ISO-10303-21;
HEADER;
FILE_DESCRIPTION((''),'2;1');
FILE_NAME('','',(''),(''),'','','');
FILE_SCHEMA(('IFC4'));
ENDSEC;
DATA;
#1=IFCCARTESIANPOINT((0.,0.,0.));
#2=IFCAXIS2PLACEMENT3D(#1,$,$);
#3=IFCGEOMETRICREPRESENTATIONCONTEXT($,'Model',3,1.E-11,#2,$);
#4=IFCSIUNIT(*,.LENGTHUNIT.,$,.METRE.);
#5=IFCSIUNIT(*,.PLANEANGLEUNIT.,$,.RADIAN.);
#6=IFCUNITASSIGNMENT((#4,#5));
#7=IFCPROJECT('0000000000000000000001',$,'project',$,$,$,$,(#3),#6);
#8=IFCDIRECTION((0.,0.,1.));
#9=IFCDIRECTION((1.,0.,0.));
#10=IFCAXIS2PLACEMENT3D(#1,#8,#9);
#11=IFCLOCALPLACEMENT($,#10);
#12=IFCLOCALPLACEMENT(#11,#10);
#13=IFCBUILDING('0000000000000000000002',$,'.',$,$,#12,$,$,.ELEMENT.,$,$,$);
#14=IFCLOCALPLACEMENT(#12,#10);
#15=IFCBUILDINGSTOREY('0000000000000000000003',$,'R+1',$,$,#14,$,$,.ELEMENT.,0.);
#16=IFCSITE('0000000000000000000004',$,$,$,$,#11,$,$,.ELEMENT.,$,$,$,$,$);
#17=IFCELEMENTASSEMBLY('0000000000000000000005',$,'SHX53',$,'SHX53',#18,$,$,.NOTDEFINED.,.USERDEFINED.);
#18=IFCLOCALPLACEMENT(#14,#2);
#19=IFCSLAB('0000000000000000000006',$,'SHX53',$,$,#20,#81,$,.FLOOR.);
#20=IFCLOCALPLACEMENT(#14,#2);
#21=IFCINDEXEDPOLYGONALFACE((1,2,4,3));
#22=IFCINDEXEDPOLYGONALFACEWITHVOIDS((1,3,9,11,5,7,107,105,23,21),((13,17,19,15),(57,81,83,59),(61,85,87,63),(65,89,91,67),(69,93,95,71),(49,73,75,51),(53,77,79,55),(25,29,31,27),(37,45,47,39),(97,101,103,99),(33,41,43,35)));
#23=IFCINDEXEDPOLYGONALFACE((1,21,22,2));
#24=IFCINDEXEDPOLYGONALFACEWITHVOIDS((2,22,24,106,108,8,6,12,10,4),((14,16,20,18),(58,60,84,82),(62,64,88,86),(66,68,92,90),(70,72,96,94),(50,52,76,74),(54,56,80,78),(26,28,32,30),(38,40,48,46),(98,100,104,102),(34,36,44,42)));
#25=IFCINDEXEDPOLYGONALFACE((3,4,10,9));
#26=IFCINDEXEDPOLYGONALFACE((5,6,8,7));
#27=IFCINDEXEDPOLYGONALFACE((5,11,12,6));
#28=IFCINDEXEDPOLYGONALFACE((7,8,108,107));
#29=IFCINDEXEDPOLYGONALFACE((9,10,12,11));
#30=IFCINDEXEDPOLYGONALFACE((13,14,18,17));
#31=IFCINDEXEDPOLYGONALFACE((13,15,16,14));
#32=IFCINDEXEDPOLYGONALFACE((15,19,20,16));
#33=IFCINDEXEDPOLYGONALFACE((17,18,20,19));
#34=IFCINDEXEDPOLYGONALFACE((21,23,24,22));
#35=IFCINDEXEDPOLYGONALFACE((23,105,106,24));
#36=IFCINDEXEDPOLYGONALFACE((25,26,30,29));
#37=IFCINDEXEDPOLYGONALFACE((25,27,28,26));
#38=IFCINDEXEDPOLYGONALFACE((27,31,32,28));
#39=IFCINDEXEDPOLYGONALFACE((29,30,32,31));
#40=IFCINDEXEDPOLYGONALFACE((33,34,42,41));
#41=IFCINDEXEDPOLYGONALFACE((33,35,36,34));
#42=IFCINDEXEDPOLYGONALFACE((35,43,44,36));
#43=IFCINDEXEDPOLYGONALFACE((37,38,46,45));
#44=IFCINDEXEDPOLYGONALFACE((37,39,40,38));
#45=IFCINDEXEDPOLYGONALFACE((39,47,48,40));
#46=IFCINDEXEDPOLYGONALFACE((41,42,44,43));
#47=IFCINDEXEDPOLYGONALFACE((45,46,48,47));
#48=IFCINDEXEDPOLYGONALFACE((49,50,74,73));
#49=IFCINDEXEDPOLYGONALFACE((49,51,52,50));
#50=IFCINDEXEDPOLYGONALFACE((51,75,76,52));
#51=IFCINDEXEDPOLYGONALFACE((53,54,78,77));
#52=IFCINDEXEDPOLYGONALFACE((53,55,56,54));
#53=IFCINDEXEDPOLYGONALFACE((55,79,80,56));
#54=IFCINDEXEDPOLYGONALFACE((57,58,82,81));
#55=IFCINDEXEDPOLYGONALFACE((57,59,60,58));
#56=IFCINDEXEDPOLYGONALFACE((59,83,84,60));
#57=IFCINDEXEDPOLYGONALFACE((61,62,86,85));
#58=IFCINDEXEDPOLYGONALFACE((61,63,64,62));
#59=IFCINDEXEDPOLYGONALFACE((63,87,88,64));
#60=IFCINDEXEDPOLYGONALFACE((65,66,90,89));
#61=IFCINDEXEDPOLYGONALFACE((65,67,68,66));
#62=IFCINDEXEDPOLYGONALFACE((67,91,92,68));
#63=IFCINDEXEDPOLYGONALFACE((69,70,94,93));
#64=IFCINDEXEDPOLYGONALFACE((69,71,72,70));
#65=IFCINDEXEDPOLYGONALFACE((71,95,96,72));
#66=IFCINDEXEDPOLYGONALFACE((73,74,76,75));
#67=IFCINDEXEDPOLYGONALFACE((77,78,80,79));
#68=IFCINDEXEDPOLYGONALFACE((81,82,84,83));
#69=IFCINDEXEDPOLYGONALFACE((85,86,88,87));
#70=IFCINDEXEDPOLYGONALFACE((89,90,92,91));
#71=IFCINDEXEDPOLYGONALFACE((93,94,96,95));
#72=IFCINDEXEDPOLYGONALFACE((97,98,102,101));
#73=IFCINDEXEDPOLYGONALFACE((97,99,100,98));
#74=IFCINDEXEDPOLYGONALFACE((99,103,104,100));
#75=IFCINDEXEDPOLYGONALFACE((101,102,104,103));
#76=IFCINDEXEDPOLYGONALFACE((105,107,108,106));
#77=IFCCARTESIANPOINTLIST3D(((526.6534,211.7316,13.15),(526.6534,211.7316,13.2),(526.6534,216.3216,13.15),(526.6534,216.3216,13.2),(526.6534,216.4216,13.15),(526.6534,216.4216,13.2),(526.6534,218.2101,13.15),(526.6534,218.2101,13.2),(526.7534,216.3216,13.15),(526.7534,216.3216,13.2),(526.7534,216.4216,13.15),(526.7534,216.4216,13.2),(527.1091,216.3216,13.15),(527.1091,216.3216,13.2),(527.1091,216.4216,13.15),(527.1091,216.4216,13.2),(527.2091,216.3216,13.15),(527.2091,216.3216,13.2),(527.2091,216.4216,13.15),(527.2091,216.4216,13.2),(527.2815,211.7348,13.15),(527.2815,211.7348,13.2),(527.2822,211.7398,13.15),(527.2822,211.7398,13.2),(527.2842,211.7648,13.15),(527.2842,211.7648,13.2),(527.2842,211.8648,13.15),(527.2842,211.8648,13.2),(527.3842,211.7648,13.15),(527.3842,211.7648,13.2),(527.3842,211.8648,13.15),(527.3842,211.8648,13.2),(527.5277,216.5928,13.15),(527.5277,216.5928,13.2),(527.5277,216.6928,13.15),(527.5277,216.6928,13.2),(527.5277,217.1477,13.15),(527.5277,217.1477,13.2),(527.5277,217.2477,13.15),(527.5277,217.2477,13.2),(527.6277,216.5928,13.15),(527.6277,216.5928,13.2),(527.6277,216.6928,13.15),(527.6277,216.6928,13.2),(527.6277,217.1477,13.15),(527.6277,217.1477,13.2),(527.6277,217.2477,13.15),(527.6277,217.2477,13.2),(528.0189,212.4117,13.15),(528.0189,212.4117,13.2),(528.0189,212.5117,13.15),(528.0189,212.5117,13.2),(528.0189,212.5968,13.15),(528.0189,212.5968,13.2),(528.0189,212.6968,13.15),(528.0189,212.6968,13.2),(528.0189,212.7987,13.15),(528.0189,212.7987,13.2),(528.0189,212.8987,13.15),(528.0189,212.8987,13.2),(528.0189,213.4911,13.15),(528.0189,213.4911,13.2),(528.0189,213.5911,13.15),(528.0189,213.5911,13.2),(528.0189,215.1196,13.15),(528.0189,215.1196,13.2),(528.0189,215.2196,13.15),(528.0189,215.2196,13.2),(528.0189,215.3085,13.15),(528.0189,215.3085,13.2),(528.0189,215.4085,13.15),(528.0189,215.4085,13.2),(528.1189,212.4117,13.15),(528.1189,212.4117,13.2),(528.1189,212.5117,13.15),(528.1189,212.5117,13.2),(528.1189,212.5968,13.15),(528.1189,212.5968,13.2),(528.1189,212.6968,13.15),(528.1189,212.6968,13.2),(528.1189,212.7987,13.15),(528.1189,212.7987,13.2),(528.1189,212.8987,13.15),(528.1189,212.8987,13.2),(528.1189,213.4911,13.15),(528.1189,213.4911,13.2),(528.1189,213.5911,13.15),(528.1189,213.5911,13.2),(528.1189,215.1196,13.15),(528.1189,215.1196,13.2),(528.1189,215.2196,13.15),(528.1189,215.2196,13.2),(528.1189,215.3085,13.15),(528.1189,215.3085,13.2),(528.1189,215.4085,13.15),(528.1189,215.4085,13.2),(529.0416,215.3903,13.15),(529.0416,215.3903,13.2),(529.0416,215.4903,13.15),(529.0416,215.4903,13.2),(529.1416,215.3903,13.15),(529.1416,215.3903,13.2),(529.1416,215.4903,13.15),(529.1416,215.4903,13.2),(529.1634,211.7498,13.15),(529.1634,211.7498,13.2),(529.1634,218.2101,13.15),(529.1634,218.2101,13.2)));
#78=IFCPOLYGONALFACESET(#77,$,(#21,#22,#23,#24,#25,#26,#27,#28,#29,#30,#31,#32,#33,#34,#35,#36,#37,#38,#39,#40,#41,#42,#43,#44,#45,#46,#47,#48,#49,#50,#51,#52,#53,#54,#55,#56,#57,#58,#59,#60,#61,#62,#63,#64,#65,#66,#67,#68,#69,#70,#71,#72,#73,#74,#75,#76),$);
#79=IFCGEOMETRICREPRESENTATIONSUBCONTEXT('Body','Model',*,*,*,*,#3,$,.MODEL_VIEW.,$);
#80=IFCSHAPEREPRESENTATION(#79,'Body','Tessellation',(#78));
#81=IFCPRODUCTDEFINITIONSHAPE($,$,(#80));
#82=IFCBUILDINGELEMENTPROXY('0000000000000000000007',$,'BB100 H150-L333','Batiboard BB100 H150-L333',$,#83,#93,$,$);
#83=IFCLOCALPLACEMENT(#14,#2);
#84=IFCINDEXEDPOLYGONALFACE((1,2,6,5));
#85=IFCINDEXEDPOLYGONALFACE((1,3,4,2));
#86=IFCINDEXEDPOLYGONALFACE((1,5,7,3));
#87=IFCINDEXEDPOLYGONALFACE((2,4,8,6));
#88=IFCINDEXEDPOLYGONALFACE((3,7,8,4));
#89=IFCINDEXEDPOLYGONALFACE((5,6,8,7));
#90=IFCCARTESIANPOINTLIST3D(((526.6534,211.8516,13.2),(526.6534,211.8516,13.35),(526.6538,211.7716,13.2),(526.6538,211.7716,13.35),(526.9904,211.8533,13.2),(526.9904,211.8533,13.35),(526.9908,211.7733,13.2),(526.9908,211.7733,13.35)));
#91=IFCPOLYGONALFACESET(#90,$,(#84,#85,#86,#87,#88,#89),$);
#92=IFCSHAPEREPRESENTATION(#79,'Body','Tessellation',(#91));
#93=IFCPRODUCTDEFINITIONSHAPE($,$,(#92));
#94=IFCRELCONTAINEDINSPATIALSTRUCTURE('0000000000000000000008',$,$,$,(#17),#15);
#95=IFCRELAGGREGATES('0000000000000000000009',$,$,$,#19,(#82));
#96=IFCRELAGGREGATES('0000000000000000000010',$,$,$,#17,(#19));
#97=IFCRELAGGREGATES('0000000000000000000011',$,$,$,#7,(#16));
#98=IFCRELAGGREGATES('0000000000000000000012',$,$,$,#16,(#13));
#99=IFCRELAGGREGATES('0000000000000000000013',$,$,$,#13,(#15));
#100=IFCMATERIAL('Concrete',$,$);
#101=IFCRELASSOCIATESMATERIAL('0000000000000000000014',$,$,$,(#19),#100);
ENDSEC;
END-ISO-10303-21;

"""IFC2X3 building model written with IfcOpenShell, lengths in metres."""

from ifc_helpers import new_model, si_unit, frame, origin, origin_with_axes, place, context, subcontext, project, spatial, polyline, outline, extrude, material, element, aggregate, save


model = new_model("IFC2X3")

# Units and contexts
model_context = context("Model", 3, precision=1e-11, world=origin())
body_context = subcontext(model_context, "Body", "Model", "MODEL_VIEW")
ifc_project = project(units=[si_unit("LENGTHUNIT", "METRE"), si_unit("PLANEANGLEUNIT", "RADIAN")], contexts=[model_context])

# Site, building, storey
site_placement = place(None, origin_with_axes())
site = spatial("IfcSite", under=ifc_project, at=site_placement, CompositionType="ELEMENT")
building_placement = place(site_placement, origin_with_axes())
building = spatial("IfcBuilding", under=site, at=building_placement, Name=".", CompositionType="ELEMENT")
storey_placement = place(building_placement, origin_with_axes())
storey = spatial("IfcBuildingStorey", under=building, at=storey_placement, Name="R+1", CompositionType="ELEMENT", Elevation=0.0)

# Element assembly, slab, openings, building element proxy
assembly_1_placement = place(storey_placement, origin_with_axes())
assembly_1 = element("IfcElementAssembly", 1, at=assembly_1_placement, inside=storey, Name="SHX53", ObjectType="SHX53", AssemblyPlace="NOTDEFINED", PredefinedType="USERDEFINED")
ifc_material = material(Name="Concrete")
slab_placement = place(assembly_1_placement, frame((529.1634, 211.7316, 13.15), z_axis=(0.0, 0.0, 1.0), x_axis=(0.0, 1.0, 0.0)))
slab = element("IfcSlab", 2, at=slab_placement, material=ifc_material, Name="SHX53", PredefinedType="FLOOR", context=body_context, shape_type="SweptSolid", body=[
    extrude(outline(polyline([(0.0, -0.0182), (0.0, -6.4785), (2.51, -6.4785), (2.51, 0.0), (1.8819, -0.0032), (1.8812, -0.0082), (0.0, -0.0182)])), frame((0.0, 0.0, 0.0), z_axis=(0.0, 0.0, 1.0), x_axis=(0.0, 1.0, 0.0)), (0.0, 0.0, 1.0), 0.05),
])
opening_1_placement = place(slab_placement, origin_with_axes())
element("IfcOpeningElement", 3, at=opening_1_placement, cuts=slab, ObjectType="Opening", context=body_context, shape_type="SweptSolid", body=[
    extrude(outline(polyline([(0.0219, -3.6588), (0.0219, -3.7588), (0.1219, -3.7588), (0.1219, -3.6588), (0.0219, -3.6588)])), frame((0.0, 0.0, 0.0), z_axis=(0.0, 0.0, 1.0), x_axis=(0.0, 1.0, 0.0)), (0.0, 0.0, 1.0), 0.05),
])
opening_2_placement = place(slab_placement, origin_with_axes())
element("IfcOpeningElement", 4, at=opening_2_placement, cuts=slab, ObjectType="Opening", context=body_context, shape_type="SweptSolid", body=[
    extrude(outline(polyline([(1.0446, -0.6802), (1.0446, -0.7802), (1.1446, -0.7802), (1.1446, -0.6802), (1.0446, -0.6802)])), frame((0.0, 0.0, 0.0), z_axis=(0.0, 0.0, 1.0), x_axis=(0.0, 1.0, 0.0)), (0.0, 0.0, 1.0), 0.05),
])
opening_3_placement = place(slab_placement, origin_with_axes())
element("IfcOpeningElement", 5, at=opening_3_placement, cuts=slab, ObjectType="Opening", context=body_context, shape_type="SweptSolid", body=[
    extrude(outline(polyline([(1.0446, -0.8652), (1.0446, -0.9652), (1.1446, -0.9652), (1.1446, -0.8652), (1.0446, -0.8652)])), frame((0.0, 0.0, 0.0), z_axis=(0.0, 0.0, 1.0), x_axis=(0.0, 1.0, 0.0)), (0.0, 0.0, 1.0), 0.05),
])
opening_4_placement = place(slab_placement, origin_with_axes())
element("IfcOpeningElement", 6, at=opening_4_placement, cuts=slab, ObjectType="Opening", context=body_context, shape_type="SweptSolid", body=[
    extrude(outline(polyline([(1.0446, -1.0672), (1.0446, -1.1672), (1.1446, -1.1672), (1.1446, -1.0672), (1.0446, -1.0672)])), frame((0.0, 0.0, 0.0), z_axis=(0.0, 0.0, 1.0), x_axis=(0.0, 1.0, 0.0)), (0.0, 0.0, 1.0), 0.05),
])
opening_5_placement = place(slab_placement, origin_with_axes())
element("IfcOpeningElement", 7, at=opening_5_placement, cuts=slab, ObjectType="Opening", context=body_context, shape_type="SweptSolid", body=[
    extrude(outline(polyline([(1.0446, -1.7595), (1.0446, -1.8595), (1.1446, -1.8595), (1.1446, -1.7595), (1.0446, -1.7595)])), frame((0.0, 0.0, 0.0), z_axis=(0.0, 0.0, 1.0), x_axis=(0.0, 1.0, 0.0)), (0.0, 0.0, 1.0), 0.05),
])
opening_6_placement = place(slab_placement, origin_with_axes())
element("IfcOpeningElement", 8, at=opening_6_placement, cuts=slab, ObjectType="Opening", context=body_context, shape_type="SweptSolid", body=[
    extrude(outline(polyline([(1.0446, -3.388), (1.0446, -3.488), (1.1446, -3.488), (1.1446, -3.388), (1.0446, -3.388)])), frame((0.0, 0.0, 0.0), z_axis=(0.0, 0.0, 1.0), x_axis=(0.0, 1.0, 0.0)), (0.0, 0.0, 1.0), 0.05),
])
opening_7_placement = place(slab_placement, origin_with_axes())
element("IfcOpeningElement", 9, at=opening_7_placement, cuts=slab, ObjectType="Opening", context=body_context, shape_type="SweptSolid", body=[
    extrude(outline(polyline([(1.0446, -3.577), (1.0446, -3.677), (1.1446, -3.677), (1.1446, -3.577), (1.0446, -3.577)])), frame((0.0, 0.0, 0.0), z_axis=(0.0, 0.0, 1.0), x_axis=(0.0, 1.0, 0.0)), (0.0, 0.0, 1.0), 0.05),
])
opening_8_placement = place(slab_placement, origin_with_axes())
element("IfcOpeningElement", 10, at=opening_8_placement, cuts=slab, ObjectType="Opening", context=body_context, shape_type="SweptSolid", body=[
    extrude(outline(polyline([(1.7792, -0.0332), (1.7792, -0.1332), (1.8792, -0.1332), (1.8792, -0.0332), (1.7792, -0.0332)])), frame((0.0, 0.0, 0.0), z_axis=(0.0, 0.0, 1.0), x_axis=(0.0, 1.0, 0.0)), (0.0, 0.0, 1.0), 0.05),
])
opening_9_placement = place(slab_placement, origin_with_axes())
element("IfcOpeningElement", 11, at=opening_9_placement, cuts=slab, ObjectType="Opening", context=body_context, shape_type="SweptSolid", body=[
    extrude(outline(polyline([(1.5358, -5.4161), (1.5358, -5.5161), (1.6358, -5.5161), (1.6358, -5.4161), (1.5358, -5.4161)])), frame((0.0, 0.0, 0.0), z_axis=(0.0, 0.0, 1.0), x_axis=(0.0, 1.0, 0.0)), (0.0, 0.0, 1.0), 0.05),
])
opening_10_placement = place(slab_placement, origin_with_axes())
element("IfcOpeningElement", 12, at=opening_10_placement, cuts=slab, ObjectType="Opening", context=body_context, shape_type="SweptSolid", body=[
    extrude(outline(polyline([(1.5358, -4.8612), (1.5358, -4.9612), (1.6358, -4.9612), (1.6358, -4.8612), (1.5358, -4.8612)])), frame((0.0, 0.0, 0.0), z_axis=(0.0, 0.0, 1.0), x_axis=(0.0, 1.0, 0.0)), (0.0, 0.0, 1.0), 0.05),
])
opening_11_placement = place(slab_placement, origin_with_axes())
element("IfcOpeningElement", 13, at=opening_11_placement, cuts=slab, ObjectType="Opening", context=body_context, shape_type="SweptSolid", body=[
    extrude(outline(polyline([(1.9543, -4.59), (1.9543, -4.69), (2.0543, -4.69), (2.0543, -4.59), (1.9543, -4.59)])), frame((0.0, 0.0, 0.0), z_axis=(0.0, 0.0, 1.0), x_axis=(0.0, 1.0, 0.0)), (0.0, 0.0, 1.0), 0.05),
])
opening_12_placement = place(slab_placement, origin_with_axes())
element("IfcOpeningElement", 14, at=opening_12_placement, cuts=slab, ObjectType="Opening", context=body_context, shape_type="SweptSolid", body=[
    extrude(outline(polyline([(2.41, -4.59), (2.41, -4.69), (2.51, -4.69), (2.51, -4.59), (2.41, -4.59)])), frame((0.0, 0.0, 0.0), z_axis=(0.0, 0.0, 1.0), x_axis=(0.0, 1.0, 0.0)), (0.0, 0.0, 1.0), 0.05),
])
proxy_placement = place(assembly_1_placement, frame((529.1634, 211.7316, 13.2), z_axis=(0.0, 0.0, 1.0), x_axis=(0.0, 1.0, 0.0)))
proxy = element("IfcBuildingElementProxy", 15, at=proxy_placement, Name="BB100 H150-L333", Description="Batiboard BB100 H150-L333", context=body_context, shape_type="SweptSolid", body=[
    extrude(outline(polyline([(2.51, -0.12), (2.5096, -0.04), (2.1726, -0.0417), (2.173, -0.1217), (2.51, -0.12)])), frame((0.0, 0.0, 0.0), z_axis=(0.0, 0.0, 1.0), x_axis=(0.0, 1.0, 0.0)), (0.0, 0.0, 1.0), 0.15),
])
aggregate(slab, [proxy])
aggregate(assembly_1, [slab])

save(model, "model.ifc")
